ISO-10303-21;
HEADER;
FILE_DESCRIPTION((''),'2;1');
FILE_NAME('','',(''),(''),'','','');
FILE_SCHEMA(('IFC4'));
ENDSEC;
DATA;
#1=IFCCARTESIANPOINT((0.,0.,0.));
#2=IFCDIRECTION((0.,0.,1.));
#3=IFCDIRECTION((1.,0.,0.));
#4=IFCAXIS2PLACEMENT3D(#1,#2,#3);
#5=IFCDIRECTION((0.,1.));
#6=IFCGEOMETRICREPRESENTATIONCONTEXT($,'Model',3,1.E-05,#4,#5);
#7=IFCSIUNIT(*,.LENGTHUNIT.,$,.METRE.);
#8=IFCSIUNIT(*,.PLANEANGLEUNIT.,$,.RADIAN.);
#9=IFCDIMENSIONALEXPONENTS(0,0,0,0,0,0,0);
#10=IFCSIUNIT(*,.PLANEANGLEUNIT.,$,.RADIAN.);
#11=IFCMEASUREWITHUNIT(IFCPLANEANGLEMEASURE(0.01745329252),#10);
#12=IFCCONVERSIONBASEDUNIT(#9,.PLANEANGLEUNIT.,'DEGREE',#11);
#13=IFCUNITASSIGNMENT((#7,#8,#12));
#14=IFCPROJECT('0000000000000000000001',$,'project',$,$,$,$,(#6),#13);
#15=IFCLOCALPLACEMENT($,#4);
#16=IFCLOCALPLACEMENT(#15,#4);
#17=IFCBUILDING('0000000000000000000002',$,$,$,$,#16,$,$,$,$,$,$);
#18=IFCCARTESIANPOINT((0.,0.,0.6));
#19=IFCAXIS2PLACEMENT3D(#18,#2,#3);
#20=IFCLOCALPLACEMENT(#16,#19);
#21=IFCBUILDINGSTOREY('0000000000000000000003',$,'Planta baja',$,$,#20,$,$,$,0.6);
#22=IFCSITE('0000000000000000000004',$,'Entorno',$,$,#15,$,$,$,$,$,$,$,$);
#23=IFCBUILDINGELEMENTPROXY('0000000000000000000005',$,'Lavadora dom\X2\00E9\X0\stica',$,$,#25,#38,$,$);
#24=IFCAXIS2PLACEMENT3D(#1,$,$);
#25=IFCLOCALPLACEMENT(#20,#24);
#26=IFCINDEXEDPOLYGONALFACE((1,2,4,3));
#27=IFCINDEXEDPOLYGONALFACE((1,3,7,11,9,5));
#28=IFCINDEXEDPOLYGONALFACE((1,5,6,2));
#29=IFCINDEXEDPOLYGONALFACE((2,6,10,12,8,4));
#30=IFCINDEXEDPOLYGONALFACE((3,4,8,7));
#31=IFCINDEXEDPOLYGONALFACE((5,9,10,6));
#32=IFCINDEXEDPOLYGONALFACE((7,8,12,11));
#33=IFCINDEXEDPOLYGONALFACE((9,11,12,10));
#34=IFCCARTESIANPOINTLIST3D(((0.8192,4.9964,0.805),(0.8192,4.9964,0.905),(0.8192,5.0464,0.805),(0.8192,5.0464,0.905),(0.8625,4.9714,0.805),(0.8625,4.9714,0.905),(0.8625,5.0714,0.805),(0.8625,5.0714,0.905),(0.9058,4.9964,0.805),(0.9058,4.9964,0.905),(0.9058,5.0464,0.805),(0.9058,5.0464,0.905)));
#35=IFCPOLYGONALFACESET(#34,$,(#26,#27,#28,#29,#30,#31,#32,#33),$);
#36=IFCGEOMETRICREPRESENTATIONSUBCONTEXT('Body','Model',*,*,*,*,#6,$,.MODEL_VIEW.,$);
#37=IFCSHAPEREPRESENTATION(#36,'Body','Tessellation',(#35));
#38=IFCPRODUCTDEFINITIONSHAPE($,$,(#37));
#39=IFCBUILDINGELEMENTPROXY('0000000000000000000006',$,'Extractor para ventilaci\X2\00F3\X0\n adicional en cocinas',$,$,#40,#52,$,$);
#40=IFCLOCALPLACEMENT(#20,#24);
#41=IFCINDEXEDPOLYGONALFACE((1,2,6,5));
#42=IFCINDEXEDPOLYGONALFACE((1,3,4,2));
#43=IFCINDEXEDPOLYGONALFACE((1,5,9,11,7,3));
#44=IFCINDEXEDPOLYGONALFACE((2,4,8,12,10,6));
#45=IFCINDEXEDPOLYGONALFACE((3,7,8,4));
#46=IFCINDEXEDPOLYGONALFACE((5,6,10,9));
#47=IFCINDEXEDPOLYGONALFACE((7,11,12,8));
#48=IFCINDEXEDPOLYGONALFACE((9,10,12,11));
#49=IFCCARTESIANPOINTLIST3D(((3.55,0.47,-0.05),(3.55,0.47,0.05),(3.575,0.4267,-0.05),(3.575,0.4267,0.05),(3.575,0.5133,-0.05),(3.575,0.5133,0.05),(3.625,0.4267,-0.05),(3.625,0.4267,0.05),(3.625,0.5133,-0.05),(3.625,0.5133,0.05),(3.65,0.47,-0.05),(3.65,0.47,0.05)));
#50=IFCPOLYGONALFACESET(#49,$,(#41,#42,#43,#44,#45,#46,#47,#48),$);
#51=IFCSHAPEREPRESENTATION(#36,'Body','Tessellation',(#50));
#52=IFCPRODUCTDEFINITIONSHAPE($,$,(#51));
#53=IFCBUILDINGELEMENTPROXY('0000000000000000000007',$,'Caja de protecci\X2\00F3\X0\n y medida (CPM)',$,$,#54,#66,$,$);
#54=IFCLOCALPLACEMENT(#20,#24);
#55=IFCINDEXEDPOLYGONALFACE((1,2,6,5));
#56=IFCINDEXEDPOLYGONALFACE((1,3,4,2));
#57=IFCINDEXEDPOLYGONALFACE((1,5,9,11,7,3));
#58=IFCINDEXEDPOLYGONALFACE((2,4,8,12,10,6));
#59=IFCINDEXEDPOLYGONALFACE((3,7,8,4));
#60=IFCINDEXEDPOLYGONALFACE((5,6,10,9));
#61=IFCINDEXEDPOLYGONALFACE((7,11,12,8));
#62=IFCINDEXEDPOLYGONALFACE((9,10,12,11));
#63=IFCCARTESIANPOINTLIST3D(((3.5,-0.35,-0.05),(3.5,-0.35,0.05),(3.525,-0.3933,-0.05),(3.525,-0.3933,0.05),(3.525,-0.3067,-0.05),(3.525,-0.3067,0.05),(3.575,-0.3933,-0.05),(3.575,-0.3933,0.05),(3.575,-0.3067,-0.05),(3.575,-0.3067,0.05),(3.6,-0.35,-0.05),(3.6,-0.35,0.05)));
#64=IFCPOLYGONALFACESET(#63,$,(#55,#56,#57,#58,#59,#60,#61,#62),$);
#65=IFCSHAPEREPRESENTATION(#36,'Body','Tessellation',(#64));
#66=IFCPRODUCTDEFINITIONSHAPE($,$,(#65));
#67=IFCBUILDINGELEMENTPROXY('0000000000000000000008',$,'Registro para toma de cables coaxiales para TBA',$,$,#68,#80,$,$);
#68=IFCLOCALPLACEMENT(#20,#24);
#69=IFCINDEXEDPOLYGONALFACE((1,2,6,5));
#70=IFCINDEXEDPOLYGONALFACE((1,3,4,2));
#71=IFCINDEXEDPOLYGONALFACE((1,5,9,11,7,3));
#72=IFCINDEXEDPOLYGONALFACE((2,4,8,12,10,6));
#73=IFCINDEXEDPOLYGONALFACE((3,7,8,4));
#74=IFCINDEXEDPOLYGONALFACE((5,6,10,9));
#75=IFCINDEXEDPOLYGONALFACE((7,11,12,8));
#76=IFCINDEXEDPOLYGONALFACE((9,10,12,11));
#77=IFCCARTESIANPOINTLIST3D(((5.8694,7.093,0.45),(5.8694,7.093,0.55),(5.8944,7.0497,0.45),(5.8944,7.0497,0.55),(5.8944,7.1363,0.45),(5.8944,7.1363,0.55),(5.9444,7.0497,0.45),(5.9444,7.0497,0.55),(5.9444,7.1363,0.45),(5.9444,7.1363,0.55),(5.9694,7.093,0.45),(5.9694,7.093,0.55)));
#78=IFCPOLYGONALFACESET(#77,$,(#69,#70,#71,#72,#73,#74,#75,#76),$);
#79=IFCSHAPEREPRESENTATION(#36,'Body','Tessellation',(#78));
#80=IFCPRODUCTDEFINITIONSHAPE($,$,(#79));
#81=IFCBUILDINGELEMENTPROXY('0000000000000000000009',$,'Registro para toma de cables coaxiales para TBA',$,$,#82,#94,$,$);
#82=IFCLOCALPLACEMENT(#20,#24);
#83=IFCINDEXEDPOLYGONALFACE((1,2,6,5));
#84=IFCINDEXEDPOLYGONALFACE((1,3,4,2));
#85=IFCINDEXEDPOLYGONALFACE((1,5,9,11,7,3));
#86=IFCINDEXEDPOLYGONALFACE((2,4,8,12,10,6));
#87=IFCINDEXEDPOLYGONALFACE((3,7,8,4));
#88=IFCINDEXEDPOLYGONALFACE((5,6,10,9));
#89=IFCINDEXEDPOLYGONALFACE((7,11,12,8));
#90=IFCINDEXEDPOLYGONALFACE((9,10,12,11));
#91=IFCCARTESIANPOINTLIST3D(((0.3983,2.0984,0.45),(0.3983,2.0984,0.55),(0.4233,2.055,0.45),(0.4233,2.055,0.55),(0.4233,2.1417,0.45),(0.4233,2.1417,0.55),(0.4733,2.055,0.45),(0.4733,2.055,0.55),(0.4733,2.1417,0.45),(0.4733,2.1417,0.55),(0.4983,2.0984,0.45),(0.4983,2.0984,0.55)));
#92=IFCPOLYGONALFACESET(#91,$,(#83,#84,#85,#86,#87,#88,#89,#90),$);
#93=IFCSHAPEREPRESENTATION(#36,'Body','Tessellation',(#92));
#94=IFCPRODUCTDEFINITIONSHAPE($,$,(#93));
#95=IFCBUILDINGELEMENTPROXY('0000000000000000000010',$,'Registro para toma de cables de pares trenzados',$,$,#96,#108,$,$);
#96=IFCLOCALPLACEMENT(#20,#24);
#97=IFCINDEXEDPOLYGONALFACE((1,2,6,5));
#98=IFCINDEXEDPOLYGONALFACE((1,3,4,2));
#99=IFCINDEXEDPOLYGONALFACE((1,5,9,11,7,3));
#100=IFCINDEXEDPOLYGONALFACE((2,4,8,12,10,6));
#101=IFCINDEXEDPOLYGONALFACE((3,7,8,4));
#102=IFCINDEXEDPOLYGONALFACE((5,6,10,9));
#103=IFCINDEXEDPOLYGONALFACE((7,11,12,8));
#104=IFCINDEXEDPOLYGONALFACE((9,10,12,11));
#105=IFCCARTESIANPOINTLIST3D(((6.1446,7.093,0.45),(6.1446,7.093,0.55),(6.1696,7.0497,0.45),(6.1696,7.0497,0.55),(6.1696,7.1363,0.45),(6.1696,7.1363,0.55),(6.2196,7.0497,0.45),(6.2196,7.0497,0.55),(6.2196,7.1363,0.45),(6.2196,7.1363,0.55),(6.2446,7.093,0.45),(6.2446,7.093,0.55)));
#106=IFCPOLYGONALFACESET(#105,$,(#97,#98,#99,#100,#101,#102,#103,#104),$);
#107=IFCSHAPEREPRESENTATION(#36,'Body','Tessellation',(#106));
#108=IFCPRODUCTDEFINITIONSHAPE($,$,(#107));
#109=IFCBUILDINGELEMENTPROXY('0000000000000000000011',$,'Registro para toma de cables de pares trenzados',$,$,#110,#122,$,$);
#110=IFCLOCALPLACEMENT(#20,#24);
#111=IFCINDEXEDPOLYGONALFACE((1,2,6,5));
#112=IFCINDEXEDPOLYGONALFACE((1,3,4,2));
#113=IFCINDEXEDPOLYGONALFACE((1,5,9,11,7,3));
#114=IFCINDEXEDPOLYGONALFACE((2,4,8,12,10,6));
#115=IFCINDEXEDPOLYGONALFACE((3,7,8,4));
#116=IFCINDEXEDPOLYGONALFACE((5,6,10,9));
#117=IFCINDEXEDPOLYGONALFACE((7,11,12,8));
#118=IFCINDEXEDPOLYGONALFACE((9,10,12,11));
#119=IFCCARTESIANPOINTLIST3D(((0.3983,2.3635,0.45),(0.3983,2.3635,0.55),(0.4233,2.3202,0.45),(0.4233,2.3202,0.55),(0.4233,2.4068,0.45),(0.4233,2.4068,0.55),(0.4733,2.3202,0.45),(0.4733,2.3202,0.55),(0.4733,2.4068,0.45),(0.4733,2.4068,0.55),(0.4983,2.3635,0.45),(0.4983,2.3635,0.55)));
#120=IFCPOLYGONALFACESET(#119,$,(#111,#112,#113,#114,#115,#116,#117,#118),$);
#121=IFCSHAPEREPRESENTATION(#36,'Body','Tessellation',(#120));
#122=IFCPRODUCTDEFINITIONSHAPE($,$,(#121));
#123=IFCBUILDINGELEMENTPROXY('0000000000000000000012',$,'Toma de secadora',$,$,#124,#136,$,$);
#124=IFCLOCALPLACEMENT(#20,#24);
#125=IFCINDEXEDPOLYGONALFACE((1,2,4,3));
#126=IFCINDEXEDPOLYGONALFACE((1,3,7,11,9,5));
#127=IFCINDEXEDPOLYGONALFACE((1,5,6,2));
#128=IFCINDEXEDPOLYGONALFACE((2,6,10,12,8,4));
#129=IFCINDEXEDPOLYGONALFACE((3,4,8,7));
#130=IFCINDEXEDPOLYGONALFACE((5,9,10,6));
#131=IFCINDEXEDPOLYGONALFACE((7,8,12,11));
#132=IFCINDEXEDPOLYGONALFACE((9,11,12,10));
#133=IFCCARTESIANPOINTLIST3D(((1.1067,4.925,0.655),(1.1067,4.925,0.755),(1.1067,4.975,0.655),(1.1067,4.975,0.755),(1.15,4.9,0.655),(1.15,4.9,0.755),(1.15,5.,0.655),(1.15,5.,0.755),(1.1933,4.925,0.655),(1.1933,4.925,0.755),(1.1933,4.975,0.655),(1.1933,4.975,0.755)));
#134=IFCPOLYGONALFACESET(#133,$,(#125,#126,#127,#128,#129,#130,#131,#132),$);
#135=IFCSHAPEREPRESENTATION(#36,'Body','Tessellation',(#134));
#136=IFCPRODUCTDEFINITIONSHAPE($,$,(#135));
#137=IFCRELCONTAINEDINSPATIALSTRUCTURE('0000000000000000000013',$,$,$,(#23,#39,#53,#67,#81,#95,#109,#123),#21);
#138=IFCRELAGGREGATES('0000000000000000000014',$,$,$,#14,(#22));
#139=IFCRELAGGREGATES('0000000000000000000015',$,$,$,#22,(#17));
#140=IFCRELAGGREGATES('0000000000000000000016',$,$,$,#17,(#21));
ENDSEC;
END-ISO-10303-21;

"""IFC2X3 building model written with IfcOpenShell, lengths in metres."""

from ifc_helpers import new_model, entity, si_unit, converted_unit, direction, frame, origin_with_axes, place, context, subcontext, project, spatial, polyline, outline, extrude, source, transform, mapped, element, save


model = new_model("IFC2X3")

# Units and contexts
model_context = context("Model", 3, precision=1e-05, world=origin_with_axes(), true_north=direction((0.0, 1.0)))
body_context = subcontext(model_context, "Body", "Model", "MODEL_VIEW")
ifc_project = project(units=[si_unit("LENGTHUNIT", "METRE"), si_unit("PLANEANGLEUNIT", "RADIAN"), converted_unit("PLANEANGLEUNIT", "DEGREE", entity("IfcPlaneAngleMeasure", 0.01745329252), si_unit("PLANEANGLEUNIT", "RADIAN"), dimensions=[0, 0, 0, 0, 0, 0, 0])], contexts=[model_context])

# Site, building, storey
site_placement = place(None, origin_with_axes())
site = spatial("IfcSite", under=ifc_project, at=site_placement, Name="Entorno")
building_placement = place(site_placement, origin_with_axes())
building = spatial("IfcBuilding", under=site, at=building_placement)
storey_placement = place(building_placement, frame((0.0, 0.0, 0.6), z_axis=(0.0, 0.0, 1.0), x_axis=(1.0, 0.0, 0.0)))
storey = spatial("IfcBuildingStorey", under=building, at=storey_placement, Name="Planta baja", Elevation=0.6)

# Building element proxies
shared_shape_1 = source(origin_with_axes(), body_context, "Body", "SolidModel", [
    extrude(outline(polyline([(0.05, 0.0), (0.025, 0.0433), (-0.025, 0.0433), (-0.05, 0.0), (-0.025, -0.0433), (0.025, -0.0433), (0.05, 0.0)])), frame((0.0, 0.0, -0.05), z_axis=(0.0, 0.0, 1.0), x_axis=(1.0, 0.0, 0.0)), (0.0, 0.0, 1.0), 0.1),
])
proxy_1_placement = place(storey_placement, frame((0.0, 0.0, -0.6), z_axis=(0.0, 0.0, 1.0), x_axis=(1.0, 0.0, 0.0)))
element("IfcBuildingElementProxy", 1, at=proxy_1_placement, inside=storey, Name="Lavadora doméstica", context=body_context, shape_type="Brep", body=[
    mapped(shared_shape_1, transform((0.8625, 5.0214, 1.455), x_axis=(0.0, 1.0, 0.0), y_axis=(-1.0, 0.0, 0.0), z_axis=(0.0, 0.0, 1.0))),
])
shared_shape_2 = source(origin_with_axes(), body_context, "Body", "SolidModel", [
    extrude(outline(polyline([(0.05, 0.0), (0.025, 0.0433), (-0.025, 0.0433), (-0.05, 0.0), (-0.025, -0.0433), (0.025, -0.0433), (0.05, 0.0)])), frame((0.0, 0.0, -0.05), z_axis=(0.0, 0.0, 1.0), x_axis=(1.0, 0.0, 0.0)), (0.0, 0.0, 1.0), 0.1),
])
proxy_2_placement = place(storey_placement, frame((0.0, 0.0, -0.6), z_axis=(0.0, 0.0, 1.0), x_axis=(1.0, 0.0, 0.0)))
element("IfcBuildingElementProxy", 2, at=proxy_2_placement, inside=storey, Name="Extractor para ventilación adicional en cocinas", context=body_context, shape_type="Brep", body=[
    mapped(shared_shape_2, transform((3.6, 0.47, 0.6), x_axis=(-1.0, 0.0, 0.0), y_axis=(0.0, -1.0, 0.0), z_axis=(0.0, 0.0, 1.0))),
])
shared_shape_3 = source(origin_with_axes(), body_context, "Body", "SolidModel", [
    extrude(outline(polyline([(0.05, 0.0), (0.025, 0.0433), (-0.025, 0.0433), (-0.05, 0.0), (-0.025, -0.0433), (0.025, -0.0433), (0.05, 0.0)])), frame((0.0, 0.0, -0.05), z_axis=(0.0, 0.0, 1.0), x_axis=(1.0, 0.0, 0.0)), (0.0, 0.0, 1.0), 0.1),
])
proxy_3_placement = place(storey_placement, frame((0.0, 0.0, -0.6), z_axis=(0.0, 0.0, 1.0), x_axis=(1.0, 0.0, 0.0)))
element("IfcBuildingElementProxy", 3, at=proxy_3_placement, inside=storey, Name="Caja de protección y medida (CPM)", context=body_context, shape_type="Brep", body=[
    mapped(shared_shape_3, transform((3.55, -0.35, 0.6), x_axis=(1.0, 0.0, 0.0), y_axis=(0.0, 1.0, 0.0), z_axis=(0.0, 0.0, 1.0))),
])
shared_shape_4 = source(origin_with_axes(), body_context, "Body", "SolidModel", [
    extrude(outline(polyline([(0.05, 0.0), (0.025, 0.0433), (-0.025, 0.0433), (-0.05, 0.0), (-0.025, -0.0433), (0.025, -0.0433), (0.05, 0.0)])), frame((0.0, 0.0, -0.05), z_axis=(0.0, 0.0, 1.0), x_axis=(1.0, 0.0, 0.0)), (0.0, 0.0, 1.0), 0.1),
])
proxy_4_placement = place(storey_placement, frame((0.0, 0.0, -0.6), z_axis=(0.0, 0.0, 1.0), x_axis=(1.0, 0.0, 0.0)))
element("IfcBuildingElementProxy", 4, at=proxy_4_placement, inside=storey, Name="Registro para toma de cables coaxiales para TBA", context=body_context, shape_type="Brep", body=[
    mapped(shared_shape_4, transform((5.9194, 7.093, 1.1), x_axis=(1.0, 0.0, 0.0), y_axis=(0.0, 1.0, 0.0), z_axis=(0.0, 0.0, 1.0))),
])
proxy_5_placement = place(storey_placement, frame((0.0, 0.0, -0.6), z_axis=(0.0, 0.0, 1.0), x_axis=(1.0, 0.0, 0.0)))
element("IfcBuildingElementProxy", 5, at=proxy_5_placement, inside=storey, Name="Registro para toma de cables coaxiales para TBA", context=body_context, shape_type="Brep", body=[
    mapped(shared_shape_4, transform((0.4483, 2.0984, 1.1), x_axis=(1.0, 0.0, 0.0), y_axis=(0.0, 1.0, 0.0), z_axis=(0.0, 0.0, 1.0))),
])
shared_shape_5 = source(origin_with_axes(), body_context, "Body", "SolidModel", [
    extrude(outline(polyline([(0.05, 0.0), (0.025, 0.0433), (-0.025, 0.0433), (-0.05, 0.0), (-0.025, -0.0433), (0.025, -0.0433), (0.05, 0.0)])), frame((0.0, 0.0, -0.05), z_axis=(0.0, 0.0, 1.0), x_axis=(1.0, 0.0, 0.0)), (0.0, 0.0, 1.0), 0.1),
])
proxy_6_placement = place(storey_placement, frame((0.0, 0.0, -0.6), z_axis=(0.0, 0.0, 1.0), x_axis=(1.0, 0.0, 0.0)))
element("IfcBuildingElementProxy", 6, at=proxy_6_placement, inside=storey, Name="Registro para toma de cables de pares trenzados", context=body_context, shape_type="Brep", body=[
    mapped(shared_shape_5, transform((6.1946, 7.093, 1.1), x_axis=(1.0, 0.0, 0.0), y_axis=(0.0, 1.0, 0.0), z_axis=(0.0, 0.0, 1.0))),
])
proxy_7_placement = place(storey_placement, frame((0.0, 0.0, -0.6), z_axis=(0.0, 0.0, 1.0), x_axis=(1.0, 0.0, 0.0)))
element("IfcBuildingElementProxy", 7, at=proxy_7_placement, inside=storey, Name="Registro para toma de cables de pares trenzados", context=body_context, shape_type="Brep", body=[
    mapped(shared_shape_5, transform((0.4483, 2.3635, 1.1), x_axis=(1.0, 0.0, 0.0), y_axis=(0.0, 1.0, 0.0), z_axis=(0.0, 0.0, 1.0))),
])
shared_shape_6 = source(origin_with_axes(), body_context, "Body", "SolidModel", [
    extrude(outline(polyline([(0.05, 0.0), (0.025, 0.0433), (-0.025, 0.0433), (-0.05, 0.0), (-0.025, -0.0433), (0.025, -0.0433), (0.05, 0.0)])), frame((0.0, 0.0, -0.05), z_axis=(0.0, 0.0, 1.0), x_axis=(1.0, 0.0, 0.0)), (0.0, 0.0, 1.0), 0.1),
])
proxy_8_placement = place(storey_placement, frame((0.0, 0.0, -0.6), z_axis=(0.0, 0.0, 1.0), x_axis=(1.0, 0.0, 0.0)))
element("IfcBuildingElementProxy", 8, at=proxy_8_placement, inside=storey, Name="Toma de secadora", context=body_context, shape_type="Brep", body=[
    mapped(shared_shape_6, transform((1.15, 4.95, 1.305), x_axis=(0.0, -1.0, 0.0), y_axis=(1.0, 0.0, 0.0), z_axis=(0.0, 0.0, 1.0))),
])

save(model, "model.ifc")
